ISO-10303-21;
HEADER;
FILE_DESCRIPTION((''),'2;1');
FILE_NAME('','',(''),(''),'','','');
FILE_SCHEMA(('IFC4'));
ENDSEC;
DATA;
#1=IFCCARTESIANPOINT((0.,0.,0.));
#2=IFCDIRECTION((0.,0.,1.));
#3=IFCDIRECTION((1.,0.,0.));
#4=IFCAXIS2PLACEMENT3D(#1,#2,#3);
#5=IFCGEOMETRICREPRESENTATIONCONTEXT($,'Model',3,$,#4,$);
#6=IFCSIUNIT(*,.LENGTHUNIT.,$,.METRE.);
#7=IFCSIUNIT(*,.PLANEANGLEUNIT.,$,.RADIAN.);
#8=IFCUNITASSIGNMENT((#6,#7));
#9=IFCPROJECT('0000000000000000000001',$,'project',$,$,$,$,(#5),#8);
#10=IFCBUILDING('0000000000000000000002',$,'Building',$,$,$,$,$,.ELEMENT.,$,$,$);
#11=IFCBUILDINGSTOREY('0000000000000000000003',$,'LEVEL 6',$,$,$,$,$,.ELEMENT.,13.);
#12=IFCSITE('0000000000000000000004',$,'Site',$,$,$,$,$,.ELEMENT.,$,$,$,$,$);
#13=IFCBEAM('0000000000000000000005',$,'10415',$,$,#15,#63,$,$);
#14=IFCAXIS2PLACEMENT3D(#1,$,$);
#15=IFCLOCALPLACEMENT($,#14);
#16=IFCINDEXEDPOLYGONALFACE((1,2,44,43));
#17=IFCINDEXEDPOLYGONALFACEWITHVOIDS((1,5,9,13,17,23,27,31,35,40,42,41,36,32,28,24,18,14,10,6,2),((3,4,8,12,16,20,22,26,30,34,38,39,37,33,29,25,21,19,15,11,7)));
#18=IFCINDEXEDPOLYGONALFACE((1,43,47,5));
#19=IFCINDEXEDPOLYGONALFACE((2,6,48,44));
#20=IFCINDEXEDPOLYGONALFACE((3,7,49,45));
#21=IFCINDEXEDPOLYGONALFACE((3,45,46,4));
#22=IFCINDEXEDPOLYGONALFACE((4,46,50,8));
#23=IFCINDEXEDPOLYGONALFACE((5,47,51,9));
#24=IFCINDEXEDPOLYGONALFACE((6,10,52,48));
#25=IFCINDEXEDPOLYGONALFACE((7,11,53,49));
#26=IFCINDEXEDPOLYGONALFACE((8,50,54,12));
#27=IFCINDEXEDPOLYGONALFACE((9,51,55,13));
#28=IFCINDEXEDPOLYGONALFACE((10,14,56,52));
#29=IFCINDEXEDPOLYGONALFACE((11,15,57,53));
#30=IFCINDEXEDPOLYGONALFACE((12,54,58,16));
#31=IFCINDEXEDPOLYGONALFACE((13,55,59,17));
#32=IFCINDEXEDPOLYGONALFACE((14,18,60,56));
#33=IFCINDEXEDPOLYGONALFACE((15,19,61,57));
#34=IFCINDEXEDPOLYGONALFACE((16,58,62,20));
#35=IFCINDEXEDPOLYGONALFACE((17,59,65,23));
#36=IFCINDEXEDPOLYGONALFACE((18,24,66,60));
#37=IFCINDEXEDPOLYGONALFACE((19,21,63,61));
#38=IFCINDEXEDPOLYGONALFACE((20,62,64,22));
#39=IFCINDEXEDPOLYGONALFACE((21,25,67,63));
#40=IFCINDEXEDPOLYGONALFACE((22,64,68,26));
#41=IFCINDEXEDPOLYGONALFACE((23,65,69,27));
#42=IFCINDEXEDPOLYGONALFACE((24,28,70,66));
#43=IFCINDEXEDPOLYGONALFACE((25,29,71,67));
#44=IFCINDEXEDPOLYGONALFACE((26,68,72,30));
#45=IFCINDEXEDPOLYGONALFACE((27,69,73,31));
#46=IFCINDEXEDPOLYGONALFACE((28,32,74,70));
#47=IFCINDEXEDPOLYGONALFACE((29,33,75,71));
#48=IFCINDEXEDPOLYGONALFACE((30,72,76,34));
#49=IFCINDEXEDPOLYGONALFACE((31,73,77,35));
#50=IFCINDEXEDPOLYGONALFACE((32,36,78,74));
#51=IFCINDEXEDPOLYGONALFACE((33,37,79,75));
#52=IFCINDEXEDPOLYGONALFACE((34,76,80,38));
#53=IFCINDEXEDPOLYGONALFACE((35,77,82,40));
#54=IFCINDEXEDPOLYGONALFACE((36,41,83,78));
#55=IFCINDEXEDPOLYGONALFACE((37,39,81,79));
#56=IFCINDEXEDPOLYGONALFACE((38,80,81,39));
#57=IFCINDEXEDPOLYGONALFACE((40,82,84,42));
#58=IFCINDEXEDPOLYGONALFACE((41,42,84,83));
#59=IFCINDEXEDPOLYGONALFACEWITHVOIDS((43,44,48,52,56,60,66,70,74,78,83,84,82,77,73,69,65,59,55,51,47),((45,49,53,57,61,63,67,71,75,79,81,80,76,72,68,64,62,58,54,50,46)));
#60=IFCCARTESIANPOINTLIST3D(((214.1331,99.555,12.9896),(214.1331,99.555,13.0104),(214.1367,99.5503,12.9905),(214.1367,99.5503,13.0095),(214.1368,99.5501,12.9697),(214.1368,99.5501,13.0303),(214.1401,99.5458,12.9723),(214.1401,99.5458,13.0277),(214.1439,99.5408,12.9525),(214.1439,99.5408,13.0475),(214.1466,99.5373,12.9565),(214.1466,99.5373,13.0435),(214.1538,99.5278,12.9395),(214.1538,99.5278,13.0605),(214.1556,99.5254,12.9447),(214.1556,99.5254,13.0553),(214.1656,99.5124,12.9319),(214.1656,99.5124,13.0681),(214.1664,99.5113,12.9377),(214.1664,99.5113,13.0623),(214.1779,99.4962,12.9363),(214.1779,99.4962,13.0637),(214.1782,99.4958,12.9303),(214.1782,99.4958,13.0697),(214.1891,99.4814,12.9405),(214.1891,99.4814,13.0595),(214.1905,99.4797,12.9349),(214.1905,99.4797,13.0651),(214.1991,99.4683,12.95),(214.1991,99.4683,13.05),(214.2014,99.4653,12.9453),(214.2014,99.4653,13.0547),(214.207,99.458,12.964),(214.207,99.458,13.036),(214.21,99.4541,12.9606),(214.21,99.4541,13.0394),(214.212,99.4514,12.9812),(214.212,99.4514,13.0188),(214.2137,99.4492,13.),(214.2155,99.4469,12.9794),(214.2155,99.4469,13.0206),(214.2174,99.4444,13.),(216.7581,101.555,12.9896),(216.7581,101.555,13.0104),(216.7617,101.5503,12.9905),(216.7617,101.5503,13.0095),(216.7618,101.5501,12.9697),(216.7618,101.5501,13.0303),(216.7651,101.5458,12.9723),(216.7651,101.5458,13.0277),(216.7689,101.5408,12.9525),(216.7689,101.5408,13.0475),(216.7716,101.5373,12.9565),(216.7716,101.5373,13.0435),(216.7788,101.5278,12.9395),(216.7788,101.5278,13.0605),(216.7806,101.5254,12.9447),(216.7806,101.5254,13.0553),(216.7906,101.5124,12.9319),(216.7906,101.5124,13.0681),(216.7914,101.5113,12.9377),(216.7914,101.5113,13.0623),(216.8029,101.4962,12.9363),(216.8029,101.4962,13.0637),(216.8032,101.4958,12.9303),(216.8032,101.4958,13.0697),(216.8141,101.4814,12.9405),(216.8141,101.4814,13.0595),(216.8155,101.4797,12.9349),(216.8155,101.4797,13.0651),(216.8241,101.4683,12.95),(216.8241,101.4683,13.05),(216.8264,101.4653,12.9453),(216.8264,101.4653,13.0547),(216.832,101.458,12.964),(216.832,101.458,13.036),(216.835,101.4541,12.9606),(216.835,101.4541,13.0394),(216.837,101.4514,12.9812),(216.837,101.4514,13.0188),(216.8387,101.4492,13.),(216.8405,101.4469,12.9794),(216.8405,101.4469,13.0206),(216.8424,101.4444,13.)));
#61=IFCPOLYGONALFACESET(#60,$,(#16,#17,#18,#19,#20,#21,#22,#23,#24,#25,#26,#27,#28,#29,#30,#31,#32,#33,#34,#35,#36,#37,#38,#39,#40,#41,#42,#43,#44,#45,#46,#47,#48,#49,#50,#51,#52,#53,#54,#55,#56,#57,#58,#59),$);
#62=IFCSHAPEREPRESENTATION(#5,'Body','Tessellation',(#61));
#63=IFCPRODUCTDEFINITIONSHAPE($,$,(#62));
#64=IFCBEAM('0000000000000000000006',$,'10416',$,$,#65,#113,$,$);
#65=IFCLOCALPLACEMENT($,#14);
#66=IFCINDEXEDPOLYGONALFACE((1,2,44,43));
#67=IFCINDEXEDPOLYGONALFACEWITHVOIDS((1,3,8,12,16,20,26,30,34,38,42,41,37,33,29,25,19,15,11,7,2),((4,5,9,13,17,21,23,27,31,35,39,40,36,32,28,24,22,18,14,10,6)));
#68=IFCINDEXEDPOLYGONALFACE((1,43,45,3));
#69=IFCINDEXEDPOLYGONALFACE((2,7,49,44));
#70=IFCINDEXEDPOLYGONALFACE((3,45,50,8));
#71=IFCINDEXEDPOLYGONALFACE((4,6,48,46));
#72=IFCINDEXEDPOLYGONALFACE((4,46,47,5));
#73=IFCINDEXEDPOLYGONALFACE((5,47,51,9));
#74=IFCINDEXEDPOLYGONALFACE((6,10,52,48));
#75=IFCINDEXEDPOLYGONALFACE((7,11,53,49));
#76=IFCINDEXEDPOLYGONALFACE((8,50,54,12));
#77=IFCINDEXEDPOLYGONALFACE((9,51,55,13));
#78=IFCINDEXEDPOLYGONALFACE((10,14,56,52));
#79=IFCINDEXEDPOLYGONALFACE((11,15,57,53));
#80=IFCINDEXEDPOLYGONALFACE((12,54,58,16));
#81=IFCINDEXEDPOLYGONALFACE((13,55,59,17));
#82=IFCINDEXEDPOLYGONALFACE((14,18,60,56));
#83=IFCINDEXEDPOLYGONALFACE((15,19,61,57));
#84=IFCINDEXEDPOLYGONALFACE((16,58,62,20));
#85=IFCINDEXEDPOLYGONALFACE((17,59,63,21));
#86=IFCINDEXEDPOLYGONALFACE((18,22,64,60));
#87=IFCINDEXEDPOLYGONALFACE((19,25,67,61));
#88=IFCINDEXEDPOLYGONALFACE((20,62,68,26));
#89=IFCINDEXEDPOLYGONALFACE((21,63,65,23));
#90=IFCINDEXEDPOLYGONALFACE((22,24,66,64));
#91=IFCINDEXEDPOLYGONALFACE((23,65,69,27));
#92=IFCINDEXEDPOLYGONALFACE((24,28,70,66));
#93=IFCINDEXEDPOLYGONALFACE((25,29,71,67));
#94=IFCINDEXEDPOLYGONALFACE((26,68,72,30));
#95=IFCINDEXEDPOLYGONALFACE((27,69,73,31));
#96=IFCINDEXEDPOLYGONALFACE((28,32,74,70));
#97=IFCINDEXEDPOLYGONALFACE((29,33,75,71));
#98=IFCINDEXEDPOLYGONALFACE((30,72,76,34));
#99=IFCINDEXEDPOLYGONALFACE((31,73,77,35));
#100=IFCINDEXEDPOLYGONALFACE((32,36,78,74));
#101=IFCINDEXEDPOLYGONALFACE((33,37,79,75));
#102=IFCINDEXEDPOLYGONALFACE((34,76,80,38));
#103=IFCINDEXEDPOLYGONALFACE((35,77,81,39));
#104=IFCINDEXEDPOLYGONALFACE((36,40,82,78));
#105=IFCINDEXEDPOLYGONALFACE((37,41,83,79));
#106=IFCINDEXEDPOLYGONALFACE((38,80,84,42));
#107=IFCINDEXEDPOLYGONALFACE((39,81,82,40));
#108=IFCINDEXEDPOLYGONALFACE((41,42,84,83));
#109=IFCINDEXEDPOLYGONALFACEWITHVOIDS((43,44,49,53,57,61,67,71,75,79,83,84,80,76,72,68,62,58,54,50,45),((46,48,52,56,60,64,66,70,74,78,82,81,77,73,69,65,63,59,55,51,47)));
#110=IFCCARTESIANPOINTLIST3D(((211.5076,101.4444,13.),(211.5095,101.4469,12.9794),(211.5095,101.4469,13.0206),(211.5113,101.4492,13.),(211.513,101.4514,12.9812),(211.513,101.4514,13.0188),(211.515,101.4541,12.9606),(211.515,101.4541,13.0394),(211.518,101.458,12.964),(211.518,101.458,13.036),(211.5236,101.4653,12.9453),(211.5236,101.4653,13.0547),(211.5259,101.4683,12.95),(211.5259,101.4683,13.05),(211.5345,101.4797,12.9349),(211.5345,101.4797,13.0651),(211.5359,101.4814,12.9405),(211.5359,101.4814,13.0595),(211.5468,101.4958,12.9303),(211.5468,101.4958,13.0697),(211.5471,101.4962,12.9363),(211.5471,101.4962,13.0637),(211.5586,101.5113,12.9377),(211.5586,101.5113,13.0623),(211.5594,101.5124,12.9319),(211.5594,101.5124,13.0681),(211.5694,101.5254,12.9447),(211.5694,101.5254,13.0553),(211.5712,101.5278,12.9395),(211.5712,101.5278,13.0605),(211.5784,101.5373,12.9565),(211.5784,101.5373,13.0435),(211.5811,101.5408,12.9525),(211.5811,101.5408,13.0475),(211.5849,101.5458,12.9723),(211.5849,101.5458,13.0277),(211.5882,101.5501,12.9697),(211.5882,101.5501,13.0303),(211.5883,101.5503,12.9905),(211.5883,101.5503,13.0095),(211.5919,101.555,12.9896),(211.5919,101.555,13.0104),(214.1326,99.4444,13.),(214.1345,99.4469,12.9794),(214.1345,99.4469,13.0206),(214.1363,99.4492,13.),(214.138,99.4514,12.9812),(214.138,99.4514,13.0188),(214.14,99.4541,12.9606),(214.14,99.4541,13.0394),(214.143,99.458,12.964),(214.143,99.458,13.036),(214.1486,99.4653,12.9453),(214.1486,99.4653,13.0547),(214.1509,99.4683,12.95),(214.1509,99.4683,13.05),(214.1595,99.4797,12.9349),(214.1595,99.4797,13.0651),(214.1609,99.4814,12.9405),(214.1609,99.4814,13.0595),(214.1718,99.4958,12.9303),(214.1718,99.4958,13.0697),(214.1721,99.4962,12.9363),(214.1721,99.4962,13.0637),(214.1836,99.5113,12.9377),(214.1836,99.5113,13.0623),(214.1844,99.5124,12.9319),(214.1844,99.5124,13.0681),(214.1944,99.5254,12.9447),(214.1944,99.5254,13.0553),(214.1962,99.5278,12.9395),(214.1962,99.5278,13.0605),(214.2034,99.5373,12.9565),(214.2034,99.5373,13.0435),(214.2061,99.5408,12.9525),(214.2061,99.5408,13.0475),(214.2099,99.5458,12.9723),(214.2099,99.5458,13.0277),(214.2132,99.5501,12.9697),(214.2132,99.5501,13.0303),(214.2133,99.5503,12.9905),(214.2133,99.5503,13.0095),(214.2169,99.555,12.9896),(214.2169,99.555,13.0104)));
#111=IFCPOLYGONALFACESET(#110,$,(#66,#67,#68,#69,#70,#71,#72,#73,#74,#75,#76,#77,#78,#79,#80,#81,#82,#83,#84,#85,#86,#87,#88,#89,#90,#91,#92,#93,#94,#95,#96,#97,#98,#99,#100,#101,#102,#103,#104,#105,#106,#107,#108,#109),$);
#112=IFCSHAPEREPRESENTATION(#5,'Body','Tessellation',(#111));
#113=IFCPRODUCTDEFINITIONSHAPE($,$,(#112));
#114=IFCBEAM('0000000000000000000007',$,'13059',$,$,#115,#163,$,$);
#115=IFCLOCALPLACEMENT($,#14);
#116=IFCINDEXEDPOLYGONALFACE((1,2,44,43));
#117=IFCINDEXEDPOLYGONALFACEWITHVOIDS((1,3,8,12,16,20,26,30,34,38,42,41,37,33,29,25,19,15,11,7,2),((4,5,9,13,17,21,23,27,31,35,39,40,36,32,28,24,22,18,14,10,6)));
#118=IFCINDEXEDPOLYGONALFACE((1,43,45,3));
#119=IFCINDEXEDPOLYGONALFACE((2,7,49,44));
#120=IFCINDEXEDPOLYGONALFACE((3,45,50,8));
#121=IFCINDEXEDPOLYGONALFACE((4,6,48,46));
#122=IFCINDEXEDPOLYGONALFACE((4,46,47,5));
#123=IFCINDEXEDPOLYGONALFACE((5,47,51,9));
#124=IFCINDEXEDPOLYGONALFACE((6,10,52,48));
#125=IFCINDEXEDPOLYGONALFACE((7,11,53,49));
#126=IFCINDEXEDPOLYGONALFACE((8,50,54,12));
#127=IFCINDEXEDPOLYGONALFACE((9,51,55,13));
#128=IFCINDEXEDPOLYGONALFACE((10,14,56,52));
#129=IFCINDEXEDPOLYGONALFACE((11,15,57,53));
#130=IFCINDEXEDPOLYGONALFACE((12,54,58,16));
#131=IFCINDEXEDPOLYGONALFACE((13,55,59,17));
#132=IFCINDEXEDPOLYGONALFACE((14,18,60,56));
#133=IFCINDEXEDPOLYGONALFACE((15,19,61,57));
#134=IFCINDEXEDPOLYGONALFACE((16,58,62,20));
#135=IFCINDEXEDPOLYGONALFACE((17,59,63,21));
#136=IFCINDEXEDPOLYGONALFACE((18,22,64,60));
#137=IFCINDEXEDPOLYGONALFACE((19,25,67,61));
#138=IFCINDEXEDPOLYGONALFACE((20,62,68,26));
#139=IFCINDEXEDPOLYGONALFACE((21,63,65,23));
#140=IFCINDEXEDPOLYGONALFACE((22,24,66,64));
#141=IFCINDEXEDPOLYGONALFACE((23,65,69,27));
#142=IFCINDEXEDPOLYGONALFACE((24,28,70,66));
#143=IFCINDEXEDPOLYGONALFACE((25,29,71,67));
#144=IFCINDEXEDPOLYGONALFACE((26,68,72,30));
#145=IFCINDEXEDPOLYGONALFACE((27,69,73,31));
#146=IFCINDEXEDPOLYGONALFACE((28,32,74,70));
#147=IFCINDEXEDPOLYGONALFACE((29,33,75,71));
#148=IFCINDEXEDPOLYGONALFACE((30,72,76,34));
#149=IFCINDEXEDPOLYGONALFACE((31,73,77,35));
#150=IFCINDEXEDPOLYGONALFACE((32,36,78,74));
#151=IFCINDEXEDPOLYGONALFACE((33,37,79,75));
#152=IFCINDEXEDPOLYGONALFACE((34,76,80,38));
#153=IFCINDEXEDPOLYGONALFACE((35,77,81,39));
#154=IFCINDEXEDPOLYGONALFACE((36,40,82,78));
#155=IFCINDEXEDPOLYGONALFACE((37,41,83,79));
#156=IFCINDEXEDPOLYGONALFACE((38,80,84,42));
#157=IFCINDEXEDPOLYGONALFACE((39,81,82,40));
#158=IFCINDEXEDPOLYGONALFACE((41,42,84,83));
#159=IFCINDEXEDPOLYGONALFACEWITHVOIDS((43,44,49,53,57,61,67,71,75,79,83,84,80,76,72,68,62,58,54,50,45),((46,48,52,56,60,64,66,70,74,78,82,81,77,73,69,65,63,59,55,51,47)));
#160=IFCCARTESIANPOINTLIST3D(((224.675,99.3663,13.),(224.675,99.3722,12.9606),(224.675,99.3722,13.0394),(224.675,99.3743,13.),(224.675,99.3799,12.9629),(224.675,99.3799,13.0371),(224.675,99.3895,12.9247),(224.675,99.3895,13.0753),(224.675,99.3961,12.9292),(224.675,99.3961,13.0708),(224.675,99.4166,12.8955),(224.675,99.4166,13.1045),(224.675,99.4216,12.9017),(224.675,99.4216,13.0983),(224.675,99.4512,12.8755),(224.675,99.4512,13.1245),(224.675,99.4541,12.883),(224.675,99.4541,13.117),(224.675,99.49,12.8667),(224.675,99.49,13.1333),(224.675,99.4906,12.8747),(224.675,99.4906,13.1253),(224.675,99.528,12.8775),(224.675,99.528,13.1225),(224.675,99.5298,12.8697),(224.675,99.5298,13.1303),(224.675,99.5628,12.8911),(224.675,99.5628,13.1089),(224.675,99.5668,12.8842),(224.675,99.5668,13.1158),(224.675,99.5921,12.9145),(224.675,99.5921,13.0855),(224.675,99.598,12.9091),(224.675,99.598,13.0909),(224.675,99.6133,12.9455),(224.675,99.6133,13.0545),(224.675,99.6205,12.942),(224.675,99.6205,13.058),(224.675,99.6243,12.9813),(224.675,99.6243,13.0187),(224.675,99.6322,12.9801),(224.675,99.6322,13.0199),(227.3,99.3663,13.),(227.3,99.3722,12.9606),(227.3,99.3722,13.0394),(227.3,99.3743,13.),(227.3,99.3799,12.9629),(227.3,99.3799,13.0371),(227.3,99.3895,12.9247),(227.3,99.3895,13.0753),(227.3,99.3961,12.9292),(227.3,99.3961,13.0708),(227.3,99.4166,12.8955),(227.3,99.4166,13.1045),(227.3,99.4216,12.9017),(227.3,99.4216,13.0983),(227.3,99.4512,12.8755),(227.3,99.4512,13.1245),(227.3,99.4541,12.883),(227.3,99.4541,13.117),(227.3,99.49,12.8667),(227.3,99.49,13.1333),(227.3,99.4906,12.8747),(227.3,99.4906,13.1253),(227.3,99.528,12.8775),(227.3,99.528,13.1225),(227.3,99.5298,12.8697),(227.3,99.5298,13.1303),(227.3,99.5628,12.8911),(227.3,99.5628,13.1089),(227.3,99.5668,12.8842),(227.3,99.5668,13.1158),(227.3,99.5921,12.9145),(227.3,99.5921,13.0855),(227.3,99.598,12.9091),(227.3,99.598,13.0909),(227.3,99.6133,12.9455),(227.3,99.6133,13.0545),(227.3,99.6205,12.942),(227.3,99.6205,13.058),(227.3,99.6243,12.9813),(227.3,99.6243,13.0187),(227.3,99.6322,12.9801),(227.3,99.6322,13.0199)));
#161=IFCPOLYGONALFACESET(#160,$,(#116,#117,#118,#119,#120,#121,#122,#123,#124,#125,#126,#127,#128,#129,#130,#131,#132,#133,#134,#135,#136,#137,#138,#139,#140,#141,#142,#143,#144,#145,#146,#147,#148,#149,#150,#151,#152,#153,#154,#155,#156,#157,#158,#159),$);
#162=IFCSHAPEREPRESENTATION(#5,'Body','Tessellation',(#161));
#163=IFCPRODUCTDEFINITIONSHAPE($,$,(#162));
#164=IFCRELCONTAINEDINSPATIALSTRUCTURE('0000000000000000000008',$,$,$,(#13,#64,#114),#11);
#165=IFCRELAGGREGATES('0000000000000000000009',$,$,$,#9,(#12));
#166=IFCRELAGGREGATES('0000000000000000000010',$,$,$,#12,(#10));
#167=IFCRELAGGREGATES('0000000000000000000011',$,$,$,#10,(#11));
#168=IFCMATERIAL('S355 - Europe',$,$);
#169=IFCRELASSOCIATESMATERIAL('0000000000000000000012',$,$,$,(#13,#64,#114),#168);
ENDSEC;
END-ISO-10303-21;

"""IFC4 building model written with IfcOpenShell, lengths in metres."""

from ifc_helpers import new_model, si_unit, frame, origin_with_axes, origin_2d_with_axis, place, context, project, spatial, hollow_circle, extrude, material, material_profile, profile_set, profile_usage, element, save


model = new_model("IFC4")

# Units and contexts
model_context = context("Model", 3, world=origin_with_axes())
ifc_project = project(units=[si_unit("LENGTHUNIT", "METRE"), si_unit("PLANEANGLEUNIT", "RADIAN")], contexts=[model_context])

# Site, building, storey
site = spatial("IfcSite", under=ifc_project, Name="Site", CompositionType="ELEMENT")
building = spatial("IfcBuilding", under=site, Name="Building", CompositionType="ELEMENT")
storey = spatial("IfcBuildingStorey", under=building, Name="LEVEL 6", CompositionType="ELEMENT", Elevation=13.0)

# Shared definitions
ifc_material = material(Name="S355 - Europe")

# Beams
ifc_material_profile_1 = material_profile(ifc_material, hollow_circle(Radius=0.0699, WallThickness=0.006, at=origin_2d_with_axis()))
ifc_profile_set_1 = profile_set([ifc_material_profile_1])
ifc_profile_usage_1 = profile_usage(ifc_profile_set_1, cardinal=10)
beam_1_placement = place(None, frame((216.8, 101.5, 13.0), z_axis=(-0.795432, -0.606043, 0.0), x_axis=(0.606043, -0.795432, 0.0)))
element("IfcBeam", 1, at=beam_1_placement, inside=storey, material=ifc_profile_usage_1, Name="10415", context=model_context, shape_type="SweptSolid", body=[
    extrude(hollow_circle(Radius=0.0699, WallThickness=0.006, at=origin_2d_with_axis()), origin_with_axes(), (0.0, 0.0, 1.0), 3.3001),
])
ifc_material_profile_2 = material_profile(ifc_material, hollow_circle(Radius=0.0699, WallThickness=0.006, at=origin_2d_with_axis()))
ifc_profile_set_2 = profile_set([ifc_material_profile_2])
ifc_profile_usage_2 = profile_usage(ifc_profile_set_2, cardinal=10)
beam_2_placement = place(None, frame((214.175, 99.5, 13.0), z_axis=(-0.795432, 0.606043, 0.0), x_axis=(-0.606043, -0.795432, 0.0)))
element("IfcBeam", 2, at=beam_2_placement, inside=storey, material=ifc_profile_usage_2, Name="10416", context=model_context, shape_type="SweptSolid", body=[
    extrude(hollow_circle(Radius=0.0699, WallThickness=0.006, at=origin_2d_with_axis()), origin_with_axes(), (0.0, 0.0, 1.0), 3.3001),
])
ifc_material_profile_3 = material_profile(ifc_material, hollow_circle(Radius=0.1337, WallThickness=0.008, at=origin_2d_with_axis()))
ifc_profile_set_3 = profile_set([ifc_material_profile_3])
ifc_profile_usage_3 = profile_usage(ifc_profile_set_3, cardinal=10)
beam_3_placement = place(None, frame((227.3, 99.5, 13.0), z_axis=(-1.0, 0.0, 0.0), x_axis=(0.0, -1.0, 0.0)))
element("IfcBeam", 3, at=beam_3_placement, inside=storey, material=ifc_profile_usage_3, Name="13059", context=model_context, shape_type="SweptSolid", body=[
    extrude(hollow_circle(Radius=0.1337, WallThickness=0.008, at=origin_2d_with_axis()), origin_with_axes(), (0.0, 0.0, 1.0), 2.625),
])

save(model, "model.ifc")
